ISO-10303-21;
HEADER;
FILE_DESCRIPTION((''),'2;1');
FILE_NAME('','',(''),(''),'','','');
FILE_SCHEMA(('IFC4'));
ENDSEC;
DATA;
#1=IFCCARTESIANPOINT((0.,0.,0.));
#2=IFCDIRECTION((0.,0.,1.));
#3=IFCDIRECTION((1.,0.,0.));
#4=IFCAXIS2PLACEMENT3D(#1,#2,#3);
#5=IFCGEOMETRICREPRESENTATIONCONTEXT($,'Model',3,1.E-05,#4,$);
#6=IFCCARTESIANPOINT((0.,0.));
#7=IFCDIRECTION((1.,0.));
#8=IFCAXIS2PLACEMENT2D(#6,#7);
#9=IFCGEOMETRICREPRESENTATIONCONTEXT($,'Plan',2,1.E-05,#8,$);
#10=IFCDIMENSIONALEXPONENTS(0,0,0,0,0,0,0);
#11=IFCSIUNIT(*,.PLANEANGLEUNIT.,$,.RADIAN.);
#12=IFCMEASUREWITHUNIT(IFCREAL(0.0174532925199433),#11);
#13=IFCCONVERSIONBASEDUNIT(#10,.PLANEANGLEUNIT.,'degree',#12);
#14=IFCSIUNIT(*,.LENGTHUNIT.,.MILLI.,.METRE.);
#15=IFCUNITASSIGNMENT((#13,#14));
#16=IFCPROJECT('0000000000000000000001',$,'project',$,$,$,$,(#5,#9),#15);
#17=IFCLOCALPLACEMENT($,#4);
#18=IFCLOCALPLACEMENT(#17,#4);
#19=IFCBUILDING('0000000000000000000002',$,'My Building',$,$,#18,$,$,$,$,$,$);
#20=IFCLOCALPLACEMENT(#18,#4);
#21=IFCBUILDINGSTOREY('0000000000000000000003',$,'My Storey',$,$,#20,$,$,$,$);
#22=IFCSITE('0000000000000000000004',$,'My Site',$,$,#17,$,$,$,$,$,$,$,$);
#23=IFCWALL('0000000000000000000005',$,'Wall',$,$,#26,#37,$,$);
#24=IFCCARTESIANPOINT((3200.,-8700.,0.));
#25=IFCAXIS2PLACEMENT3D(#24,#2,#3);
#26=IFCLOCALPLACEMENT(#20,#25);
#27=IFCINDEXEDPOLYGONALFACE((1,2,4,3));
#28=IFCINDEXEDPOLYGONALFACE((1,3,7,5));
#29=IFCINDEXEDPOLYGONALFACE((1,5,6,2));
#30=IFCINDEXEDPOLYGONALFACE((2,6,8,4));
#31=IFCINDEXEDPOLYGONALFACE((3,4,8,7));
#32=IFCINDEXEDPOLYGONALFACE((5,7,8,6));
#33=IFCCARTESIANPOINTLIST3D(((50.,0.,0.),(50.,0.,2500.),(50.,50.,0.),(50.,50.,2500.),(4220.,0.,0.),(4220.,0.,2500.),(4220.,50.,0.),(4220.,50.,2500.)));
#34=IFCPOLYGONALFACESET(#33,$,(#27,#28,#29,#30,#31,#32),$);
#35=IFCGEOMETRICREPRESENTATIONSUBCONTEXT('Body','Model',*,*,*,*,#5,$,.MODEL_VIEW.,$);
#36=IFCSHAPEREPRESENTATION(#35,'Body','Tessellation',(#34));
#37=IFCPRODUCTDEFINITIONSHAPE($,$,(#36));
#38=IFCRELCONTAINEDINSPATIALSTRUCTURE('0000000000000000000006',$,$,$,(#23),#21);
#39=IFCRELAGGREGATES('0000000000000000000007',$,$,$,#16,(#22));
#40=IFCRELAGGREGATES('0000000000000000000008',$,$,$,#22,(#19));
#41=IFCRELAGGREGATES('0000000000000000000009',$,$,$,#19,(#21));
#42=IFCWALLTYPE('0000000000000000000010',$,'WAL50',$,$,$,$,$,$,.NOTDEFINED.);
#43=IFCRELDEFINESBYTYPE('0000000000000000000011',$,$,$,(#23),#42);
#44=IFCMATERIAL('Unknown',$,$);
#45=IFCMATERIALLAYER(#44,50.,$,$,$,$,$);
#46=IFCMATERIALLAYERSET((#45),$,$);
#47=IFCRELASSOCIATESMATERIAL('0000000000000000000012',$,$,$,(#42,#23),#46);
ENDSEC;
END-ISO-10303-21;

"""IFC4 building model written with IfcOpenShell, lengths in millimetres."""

from ifc_helpers import new_model, entity, si_unit, converted_unit, frame, origin_with_axes, origin_2d_with_axis, place, context, subcontext, project, spatial, line, indexed_curve, outline, extrude, material, layer, layer_set, layer_usage, type_object, element, save


model = new_model("IFC4")

# Units and contexts
model_context = context("Model", 3, precision=1e-05, world=origin_with_axes())
plan_context = context("Plan", 2, precision=1e-05, world=origin_2d_with_axis())
body_context_1 = subcontext(model_context, "Body", "Model", "MODEL_VIEW")
ifc_project = project(units=[converted_unit("PLANEANGLEUNIT", "degree", entity("IfcReal", 0.0174532925199433), si_unit("PLANEANGLEUNIT", "RADIAN"), dimensions=[0, 0, 0, 0, 0, 0, 0]), si_unit("LENGTHUNIT", "METRE", prefix="MILLI")], contexts=[model_context, plan_context])

# Site, building, storey
site_placement = place(None, origin_with_axes())
site = spatial("IfcSite", under=ifc_project, at=site_placement, Name="My Site")
building_placement = place(site_placement, origin_with_axes())
building = spatial("IfcBuilding", under=site, at=building_placement, Name="My Building")
storey_placement = place(building_placement, origin_with_axes())
storey = spatial("IfcBuildingStorey", under=building, at=storey_placement, Name="My Storey")

# Shared definitions
ifc_material = material(Name="Unknown")

# Wall
ifc_layer_1 = layer(ifc_material, 50.0)
ifc_layer_set_1 = layer_set([ifc_layer_1])
wall_type_1 = type_object("IfcWallType", Name="WAL50", PredefinedType="NOTDEFINED", material=ifc_layer_set_1)
ifc_layer_usage_1 = layer_usage(ifc_layer_set_1, "AXIS2", "POSITIVE", 0.0)
wall_1_placement = place(storey_placement, frame((3200.0, -8700.0, 0.0), z_axis=(0.0, 0.0, 1.0), x_axis=(1.0, 0.0, 0.0)))
element("IfcWall", 1, at=wall_1_placement, inside=storey, type_object=wall_type_1, material=ifc_layer_usage_1, Name="Wall", context=body_context_1, shape_type="SweptSolid", body=[
    extrude(outline(indexed_curve([(50.0, 0.0), (50.0, 50.0), (4220.0, 50.0), (4220.0, 0.0)], segments=[line(1, 2, 3, 4, 1)])), origin_with_axes(), (0.0, 0.0, 1.0), 2500.0),
])

save(model, "model.ifc")
